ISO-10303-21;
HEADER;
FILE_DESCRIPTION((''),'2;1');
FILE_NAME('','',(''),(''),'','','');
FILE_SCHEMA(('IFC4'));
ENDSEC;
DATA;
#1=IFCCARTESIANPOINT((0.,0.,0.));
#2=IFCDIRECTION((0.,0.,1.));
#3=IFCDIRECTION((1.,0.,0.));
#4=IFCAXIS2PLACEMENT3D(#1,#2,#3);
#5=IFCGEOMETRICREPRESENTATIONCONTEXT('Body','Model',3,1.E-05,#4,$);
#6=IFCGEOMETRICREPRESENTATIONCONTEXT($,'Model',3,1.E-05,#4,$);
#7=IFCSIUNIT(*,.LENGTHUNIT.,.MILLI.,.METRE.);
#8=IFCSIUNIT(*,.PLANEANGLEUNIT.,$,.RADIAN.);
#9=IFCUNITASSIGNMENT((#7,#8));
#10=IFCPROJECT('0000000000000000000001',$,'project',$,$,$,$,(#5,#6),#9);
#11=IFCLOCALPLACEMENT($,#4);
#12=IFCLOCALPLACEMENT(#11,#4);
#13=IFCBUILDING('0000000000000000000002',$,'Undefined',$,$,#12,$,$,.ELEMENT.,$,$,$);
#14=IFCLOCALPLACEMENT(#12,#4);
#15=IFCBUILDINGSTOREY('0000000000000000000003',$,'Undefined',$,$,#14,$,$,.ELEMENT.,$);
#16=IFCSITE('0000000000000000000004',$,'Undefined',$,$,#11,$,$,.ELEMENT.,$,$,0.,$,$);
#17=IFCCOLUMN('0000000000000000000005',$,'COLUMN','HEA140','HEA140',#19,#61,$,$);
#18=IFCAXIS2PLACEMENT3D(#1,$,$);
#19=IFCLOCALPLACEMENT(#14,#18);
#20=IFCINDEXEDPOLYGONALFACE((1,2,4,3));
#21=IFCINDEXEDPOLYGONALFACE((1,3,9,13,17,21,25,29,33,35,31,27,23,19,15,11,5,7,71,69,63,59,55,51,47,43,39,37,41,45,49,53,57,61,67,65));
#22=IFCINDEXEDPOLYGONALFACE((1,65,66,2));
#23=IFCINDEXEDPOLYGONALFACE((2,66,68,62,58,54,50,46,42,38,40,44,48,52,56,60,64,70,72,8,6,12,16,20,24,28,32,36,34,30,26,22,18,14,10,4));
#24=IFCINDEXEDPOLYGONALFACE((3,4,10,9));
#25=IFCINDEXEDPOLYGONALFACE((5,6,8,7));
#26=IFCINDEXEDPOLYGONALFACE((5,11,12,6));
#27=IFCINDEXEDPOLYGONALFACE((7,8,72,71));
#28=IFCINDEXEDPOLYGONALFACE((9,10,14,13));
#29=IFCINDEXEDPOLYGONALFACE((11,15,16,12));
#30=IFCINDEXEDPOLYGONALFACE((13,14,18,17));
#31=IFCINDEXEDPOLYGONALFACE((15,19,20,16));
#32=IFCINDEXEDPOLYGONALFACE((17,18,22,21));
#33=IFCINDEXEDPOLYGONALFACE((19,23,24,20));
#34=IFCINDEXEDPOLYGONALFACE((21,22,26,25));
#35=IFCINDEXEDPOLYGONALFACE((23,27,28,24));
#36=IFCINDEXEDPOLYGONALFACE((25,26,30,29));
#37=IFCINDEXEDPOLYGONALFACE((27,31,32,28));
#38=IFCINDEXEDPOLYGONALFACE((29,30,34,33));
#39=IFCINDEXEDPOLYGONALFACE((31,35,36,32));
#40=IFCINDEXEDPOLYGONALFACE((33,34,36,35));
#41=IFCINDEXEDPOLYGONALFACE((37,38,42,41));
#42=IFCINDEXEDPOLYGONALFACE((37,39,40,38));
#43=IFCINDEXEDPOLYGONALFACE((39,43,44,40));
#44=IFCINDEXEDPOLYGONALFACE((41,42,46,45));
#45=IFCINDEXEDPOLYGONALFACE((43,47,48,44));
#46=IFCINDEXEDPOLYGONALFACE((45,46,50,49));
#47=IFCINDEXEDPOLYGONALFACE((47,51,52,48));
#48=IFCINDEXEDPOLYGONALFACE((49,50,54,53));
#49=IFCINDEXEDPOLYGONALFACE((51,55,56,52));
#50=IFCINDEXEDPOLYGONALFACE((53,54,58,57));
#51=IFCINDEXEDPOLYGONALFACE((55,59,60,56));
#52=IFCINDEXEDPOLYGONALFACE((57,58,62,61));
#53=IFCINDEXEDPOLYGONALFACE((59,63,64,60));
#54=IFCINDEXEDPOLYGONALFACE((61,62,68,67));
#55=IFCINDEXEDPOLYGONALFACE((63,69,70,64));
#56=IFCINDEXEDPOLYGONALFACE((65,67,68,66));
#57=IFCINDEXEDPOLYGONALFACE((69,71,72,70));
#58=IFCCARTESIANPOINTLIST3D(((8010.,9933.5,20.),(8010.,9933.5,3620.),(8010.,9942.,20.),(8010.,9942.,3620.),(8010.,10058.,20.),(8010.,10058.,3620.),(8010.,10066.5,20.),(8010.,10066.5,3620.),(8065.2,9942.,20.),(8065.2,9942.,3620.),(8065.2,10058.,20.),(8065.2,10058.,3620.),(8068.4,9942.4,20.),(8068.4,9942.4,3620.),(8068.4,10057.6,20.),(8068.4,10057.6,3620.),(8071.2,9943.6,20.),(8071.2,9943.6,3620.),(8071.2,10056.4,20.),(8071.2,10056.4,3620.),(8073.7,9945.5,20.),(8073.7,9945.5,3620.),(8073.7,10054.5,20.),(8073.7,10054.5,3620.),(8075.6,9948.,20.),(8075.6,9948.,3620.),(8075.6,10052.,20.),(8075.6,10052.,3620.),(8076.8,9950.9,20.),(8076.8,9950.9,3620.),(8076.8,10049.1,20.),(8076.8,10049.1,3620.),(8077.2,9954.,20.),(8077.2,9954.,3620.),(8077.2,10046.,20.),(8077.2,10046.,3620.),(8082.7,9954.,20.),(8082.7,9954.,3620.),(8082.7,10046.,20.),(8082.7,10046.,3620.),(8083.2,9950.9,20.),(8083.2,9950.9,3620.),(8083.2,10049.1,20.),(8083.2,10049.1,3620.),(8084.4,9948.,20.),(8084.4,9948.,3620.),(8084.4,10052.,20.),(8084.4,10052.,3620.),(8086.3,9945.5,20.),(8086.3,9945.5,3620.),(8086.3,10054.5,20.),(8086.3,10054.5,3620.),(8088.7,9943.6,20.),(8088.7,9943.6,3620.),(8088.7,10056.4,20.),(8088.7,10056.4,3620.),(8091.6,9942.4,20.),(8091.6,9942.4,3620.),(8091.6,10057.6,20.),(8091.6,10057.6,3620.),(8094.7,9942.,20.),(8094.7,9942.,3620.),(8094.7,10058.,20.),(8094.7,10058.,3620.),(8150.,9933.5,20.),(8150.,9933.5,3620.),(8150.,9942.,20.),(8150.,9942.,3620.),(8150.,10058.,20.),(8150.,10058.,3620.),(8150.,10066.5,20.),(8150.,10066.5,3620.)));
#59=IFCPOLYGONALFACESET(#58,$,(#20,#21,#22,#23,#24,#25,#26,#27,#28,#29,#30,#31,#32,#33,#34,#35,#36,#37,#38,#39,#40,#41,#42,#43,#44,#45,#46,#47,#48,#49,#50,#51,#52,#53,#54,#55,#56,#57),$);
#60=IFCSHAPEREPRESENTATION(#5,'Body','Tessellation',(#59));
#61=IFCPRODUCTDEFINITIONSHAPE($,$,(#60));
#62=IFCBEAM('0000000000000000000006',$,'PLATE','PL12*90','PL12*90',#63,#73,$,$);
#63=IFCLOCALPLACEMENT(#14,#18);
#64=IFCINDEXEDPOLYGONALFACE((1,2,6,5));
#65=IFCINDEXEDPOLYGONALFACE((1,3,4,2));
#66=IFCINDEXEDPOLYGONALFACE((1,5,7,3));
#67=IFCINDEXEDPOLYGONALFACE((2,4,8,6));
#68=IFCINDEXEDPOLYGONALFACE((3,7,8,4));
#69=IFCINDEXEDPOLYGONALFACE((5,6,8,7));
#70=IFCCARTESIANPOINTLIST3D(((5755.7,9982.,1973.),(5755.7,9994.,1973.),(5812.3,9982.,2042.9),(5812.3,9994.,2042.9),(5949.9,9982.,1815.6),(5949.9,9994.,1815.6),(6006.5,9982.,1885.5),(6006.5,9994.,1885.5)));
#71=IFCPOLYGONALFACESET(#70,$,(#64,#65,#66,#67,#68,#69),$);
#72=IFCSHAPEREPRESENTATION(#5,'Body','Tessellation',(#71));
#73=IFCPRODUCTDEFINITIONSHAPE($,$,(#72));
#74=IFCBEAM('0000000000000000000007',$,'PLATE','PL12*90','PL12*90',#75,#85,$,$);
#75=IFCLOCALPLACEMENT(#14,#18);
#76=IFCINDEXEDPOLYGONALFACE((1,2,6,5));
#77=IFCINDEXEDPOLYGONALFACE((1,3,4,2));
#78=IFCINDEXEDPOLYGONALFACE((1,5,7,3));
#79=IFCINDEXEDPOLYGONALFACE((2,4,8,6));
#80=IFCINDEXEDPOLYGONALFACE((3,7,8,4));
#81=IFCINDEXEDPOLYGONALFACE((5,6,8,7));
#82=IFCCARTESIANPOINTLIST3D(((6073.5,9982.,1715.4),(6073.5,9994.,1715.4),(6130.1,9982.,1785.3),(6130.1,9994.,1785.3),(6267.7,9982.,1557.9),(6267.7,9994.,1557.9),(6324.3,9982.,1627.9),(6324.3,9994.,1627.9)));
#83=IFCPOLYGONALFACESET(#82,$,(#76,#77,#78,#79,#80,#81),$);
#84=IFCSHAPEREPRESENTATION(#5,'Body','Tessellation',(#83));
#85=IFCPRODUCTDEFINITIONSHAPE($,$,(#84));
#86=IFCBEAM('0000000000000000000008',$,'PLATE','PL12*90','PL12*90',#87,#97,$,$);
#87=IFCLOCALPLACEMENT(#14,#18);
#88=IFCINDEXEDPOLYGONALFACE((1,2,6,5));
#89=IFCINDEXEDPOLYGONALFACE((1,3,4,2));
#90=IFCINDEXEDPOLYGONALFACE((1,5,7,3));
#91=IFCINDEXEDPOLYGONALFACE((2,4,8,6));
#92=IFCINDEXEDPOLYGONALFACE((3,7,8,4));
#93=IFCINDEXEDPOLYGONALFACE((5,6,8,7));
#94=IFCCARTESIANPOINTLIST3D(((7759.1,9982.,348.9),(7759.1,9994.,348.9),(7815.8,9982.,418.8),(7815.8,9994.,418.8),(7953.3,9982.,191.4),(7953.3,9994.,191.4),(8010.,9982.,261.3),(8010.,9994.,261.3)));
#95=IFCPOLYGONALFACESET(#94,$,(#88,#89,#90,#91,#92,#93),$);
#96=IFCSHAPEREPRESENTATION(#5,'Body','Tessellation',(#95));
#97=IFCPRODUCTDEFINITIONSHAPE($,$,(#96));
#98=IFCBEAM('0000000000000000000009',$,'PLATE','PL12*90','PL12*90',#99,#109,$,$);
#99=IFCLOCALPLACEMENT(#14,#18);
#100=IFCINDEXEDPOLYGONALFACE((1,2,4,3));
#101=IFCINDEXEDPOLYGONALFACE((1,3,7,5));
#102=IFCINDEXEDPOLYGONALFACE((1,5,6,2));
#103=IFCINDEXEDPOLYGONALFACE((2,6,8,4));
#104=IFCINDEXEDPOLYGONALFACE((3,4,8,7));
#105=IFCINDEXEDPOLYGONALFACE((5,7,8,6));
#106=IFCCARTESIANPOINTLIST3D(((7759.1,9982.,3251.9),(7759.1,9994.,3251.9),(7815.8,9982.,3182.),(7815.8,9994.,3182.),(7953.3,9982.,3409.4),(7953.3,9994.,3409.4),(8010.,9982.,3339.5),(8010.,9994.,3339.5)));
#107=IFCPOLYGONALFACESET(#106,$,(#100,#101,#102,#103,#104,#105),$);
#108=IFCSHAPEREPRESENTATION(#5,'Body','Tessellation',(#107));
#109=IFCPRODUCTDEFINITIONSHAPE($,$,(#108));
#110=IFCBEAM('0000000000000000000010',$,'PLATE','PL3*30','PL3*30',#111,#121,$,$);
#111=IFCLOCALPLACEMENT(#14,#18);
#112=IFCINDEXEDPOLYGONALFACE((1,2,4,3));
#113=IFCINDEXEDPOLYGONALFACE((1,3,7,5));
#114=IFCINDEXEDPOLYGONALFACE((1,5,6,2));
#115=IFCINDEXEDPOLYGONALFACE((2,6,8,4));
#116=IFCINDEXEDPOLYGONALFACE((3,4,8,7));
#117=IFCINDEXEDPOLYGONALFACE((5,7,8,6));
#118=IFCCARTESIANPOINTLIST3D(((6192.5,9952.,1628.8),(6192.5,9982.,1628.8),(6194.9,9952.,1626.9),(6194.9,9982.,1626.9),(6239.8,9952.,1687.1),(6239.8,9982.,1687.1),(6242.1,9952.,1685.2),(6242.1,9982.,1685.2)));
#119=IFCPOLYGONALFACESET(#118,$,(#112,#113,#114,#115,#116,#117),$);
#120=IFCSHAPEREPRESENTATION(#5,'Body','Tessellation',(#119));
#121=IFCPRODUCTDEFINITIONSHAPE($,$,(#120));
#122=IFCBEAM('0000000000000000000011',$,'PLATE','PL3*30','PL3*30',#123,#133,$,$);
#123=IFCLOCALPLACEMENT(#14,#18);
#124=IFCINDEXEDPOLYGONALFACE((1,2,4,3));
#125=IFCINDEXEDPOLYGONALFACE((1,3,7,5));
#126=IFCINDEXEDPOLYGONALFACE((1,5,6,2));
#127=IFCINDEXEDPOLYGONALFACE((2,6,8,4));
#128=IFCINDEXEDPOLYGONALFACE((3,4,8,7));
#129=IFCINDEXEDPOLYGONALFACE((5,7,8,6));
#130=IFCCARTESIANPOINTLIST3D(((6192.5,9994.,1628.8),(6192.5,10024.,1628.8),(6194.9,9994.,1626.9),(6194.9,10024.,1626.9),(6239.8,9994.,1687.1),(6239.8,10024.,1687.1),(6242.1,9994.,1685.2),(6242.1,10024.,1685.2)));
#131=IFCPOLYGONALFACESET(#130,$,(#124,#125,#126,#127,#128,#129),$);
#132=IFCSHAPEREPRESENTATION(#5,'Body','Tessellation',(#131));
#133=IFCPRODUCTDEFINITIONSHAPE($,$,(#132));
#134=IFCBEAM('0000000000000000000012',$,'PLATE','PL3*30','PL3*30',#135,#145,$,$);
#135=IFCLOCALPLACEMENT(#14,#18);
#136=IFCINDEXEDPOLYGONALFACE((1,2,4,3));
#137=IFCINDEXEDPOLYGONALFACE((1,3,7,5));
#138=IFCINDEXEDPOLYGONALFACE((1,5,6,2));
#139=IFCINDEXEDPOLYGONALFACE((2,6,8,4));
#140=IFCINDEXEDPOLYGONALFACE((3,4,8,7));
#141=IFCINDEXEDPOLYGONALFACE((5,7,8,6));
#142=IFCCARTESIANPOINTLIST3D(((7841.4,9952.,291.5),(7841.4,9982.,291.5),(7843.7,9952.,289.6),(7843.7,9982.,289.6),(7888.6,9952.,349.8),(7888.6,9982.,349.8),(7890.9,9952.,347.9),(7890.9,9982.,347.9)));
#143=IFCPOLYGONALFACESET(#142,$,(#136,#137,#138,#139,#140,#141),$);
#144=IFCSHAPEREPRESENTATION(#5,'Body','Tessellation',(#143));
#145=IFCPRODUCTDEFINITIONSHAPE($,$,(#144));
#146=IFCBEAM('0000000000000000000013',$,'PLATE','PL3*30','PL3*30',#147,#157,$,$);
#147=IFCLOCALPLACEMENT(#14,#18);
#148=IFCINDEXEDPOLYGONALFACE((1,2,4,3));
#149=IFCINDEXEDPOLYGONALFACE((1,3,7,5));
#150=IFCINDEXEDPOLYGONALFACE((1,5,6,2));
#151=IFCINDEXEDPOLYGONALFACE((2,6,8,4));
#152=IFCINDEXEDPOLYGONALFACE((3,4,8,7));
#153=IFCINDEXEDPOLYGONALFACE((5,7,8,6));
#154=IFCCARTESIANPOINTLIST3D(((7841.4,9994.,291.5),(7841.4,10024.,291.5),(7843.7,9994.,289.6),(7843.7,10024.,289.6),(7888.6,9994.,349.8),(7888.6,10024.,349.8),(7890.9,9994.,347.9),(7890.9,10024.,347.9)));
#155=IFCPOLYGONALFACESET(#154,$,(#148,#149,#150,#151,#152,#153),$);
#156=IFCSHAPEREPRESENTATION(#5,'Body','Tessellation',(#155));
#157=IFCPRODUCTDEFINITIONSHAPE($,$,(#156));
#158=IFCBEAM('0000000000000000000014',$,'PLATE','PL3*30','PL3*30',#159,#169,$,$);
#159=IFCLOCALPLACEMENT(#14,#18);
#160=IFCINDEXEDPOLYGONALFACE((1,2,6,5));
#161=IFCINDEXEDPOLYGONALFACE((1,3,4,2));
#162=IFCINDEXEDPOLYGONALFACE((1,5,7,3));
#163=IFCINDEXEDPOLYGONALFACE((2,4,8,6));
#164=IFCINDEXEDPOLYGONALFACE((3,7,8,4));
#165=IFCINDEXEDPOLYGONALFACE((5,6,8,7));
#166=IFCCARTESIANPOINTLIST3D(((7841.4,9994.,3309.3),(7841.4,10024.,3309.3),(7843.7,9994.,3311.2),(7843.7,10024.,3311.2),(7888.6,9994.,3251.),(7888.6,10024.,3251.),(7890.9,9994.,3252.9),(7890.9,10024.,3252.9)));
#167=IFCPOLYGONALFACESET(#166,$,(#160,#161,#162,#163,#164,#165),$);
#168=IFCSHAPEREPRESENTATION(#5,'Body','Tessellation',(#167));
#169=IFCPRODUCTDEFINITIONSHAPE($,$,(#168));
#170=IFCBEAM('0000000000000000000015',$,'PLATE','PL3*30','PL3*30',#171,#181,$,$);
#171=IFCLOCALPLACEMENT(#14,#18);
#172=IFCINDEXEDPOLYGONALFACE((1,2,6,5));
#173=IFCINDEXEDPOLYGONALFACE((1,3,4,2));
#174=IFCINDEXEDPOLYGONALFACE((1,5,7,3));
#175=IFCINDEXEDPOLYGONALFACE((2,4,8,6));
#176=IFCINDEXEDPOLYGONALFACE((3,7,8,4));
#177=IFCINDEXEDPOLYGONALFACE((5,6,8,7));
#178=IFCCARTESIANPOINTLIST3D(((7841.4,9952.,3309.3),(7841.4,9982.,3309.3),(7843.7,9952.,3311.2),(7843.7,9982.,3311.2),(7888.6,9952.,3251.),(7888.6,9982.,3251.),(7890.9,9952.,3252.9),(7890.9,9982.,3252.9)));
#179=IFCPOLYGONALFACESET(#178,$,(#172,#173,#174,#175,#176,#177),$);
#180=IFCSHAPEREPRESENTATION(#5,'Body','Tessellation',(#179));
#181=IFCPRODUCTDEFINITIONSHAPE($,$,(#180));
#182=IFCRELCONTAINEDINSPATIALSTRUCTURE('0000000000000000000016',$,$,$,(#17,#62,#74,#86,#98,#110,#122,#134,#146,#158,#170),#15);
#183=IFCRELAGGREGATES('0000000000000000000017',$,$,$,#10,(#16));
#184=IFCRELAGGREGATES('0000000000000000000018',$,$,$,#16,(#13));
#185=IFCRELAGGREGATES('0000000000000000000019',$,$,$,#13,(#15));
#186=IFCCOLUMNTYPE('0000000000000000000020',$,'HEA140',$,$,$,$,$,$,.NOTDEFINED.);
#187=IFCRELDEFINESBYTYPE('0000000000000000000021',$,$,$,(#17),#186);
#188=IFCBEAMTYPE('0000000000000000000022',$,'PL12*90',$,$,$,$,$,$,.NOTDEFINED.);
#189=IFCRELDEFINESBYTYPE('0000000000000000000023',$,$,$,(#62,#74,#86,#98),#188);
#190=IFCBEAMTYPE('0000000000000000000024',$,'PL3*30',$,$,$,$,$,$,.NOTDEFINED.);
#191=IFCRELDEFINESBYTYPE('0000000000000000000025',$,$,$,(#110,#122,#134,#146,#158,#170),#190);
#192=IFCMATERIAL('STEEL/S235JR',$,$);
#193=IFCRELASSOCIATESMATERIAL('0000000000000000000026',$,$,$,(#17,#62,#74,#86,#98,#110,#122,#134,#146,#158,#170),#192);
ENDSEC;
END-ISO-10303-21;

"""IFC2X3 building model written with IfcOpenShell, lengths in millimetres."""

from ifc_helpers import new_model, si_unit, frame, origin_with_axes, origin_2d_with_axis, place, context, project, spatial, rectangle, i_section, extrude, material, type_object, element, save


model = new_model("IFC2X3")

# Units and contexts
model_context_1 = context("Model", 3, precision=1e-05, world=origin_with_axes(), identifier="Body")
model_context_2 = context("Model", 3, precision=1e-05, world=origin_with_axes())
ifc_project = project(units=[si_unit("LENGTHUNIT", "METRE", prefix="MILLI"), si_unit("PLANEANGLEUNIT", "RADIAN")], contexts=[model_context_1, model_context_2])

# Site, building, storey
site_placement = place(None, origin_with_axes())
site = spatial("IfcSite", under=ifc_project, at=site_placement, Name="Undefined", CompositionType="ELEMENT", RefElevation=0.0)
building_placement = place(site_placement, origin_with_axes())
building = spatial("IfcBuilding", under=site, at=building_placement, Name="Undefined", CompositionType="ELEMENT")
storey_placement = place(building_placement, origin_with_axes())
storey = spatial("IfcBuildingStorey", under=building, at=storey_placement, Name="Undefined", CompositionType="ELEMENT")

# Column
ifc_material = material(Name="STEEL/S235JR")
column_type = type_object("IfcColumnType", Name="HEA140", PredefinedType="NOTDEFINED")
column_placement = place(storey_placement, frame((8080.0, 10000.0, -180.0), z_axis=(0.0, 0.0, 1.0), x_axis=(1.0, 0.0, 0.0)))
element("IfcColumn", 1, at=column_placement, inside=storey, type_object=column_type, material=ifc_material, Name="COLUMN", Description="HEA140", ObjectType="HEA140", context=model_context_1, shape_type="SweptSolid", body=[
    extrude(i_section(OverallWidth=140.0, OverallDepth=133.0, WebThickness=5.5, FlangeThickness=8.5, FilletRadius=12.0, at=origin_2d_with_axis()), frame((0.0, 0.0, 3800.0), z_axis=(0.0, 0.0, -1.0), x_axis=(-1.0, 0.0, 0.0)), (0.0, 0.0, 1.0), 3600.0),
])

# Beams
beam_type_1 = type_object("IfcBeamType", Name="PL12*90", PredefinedType="NOTDEFINED")
for number, where, z_axis, x_axis, name in (
    (2, (5978.2, 9988.0, 1850.5), (0.629738, 0.0, 0.776808), (-0.776808, 0.0, 0.629738), "PLATE"),
    (3, (6101.8, 9988.0, 1750.3), (0.629738, 0.0, 0.776808), (0.776808, 0.0, -0.629738), "PLATE"),
    (4, (7981.7, 9988.0, 226.4), (-0.629738, 0.0, -0.776808), (-0.776808, 0.0, 0.629738), "PLATE"),
):
    element("IfcBeam", number, at=place(storey_placement, frame(where, z_axis=z_axis, x_axis=x_axis)), inside=storey, type_object=beam_type_1, material=ifc_material, Name=name, Description="PL12*90", ObjectType="PL12*90", context=model_context_1, shape_type="SweptSolid", body=[
        extrude(rectangle(XDim=12.0, YDim=90.0, at=origin_2d_with_axis()), frame((250.0, 0.0, 0.0), z_axis=(-1.0, 0.0, 0.0), x_axis=(0.0, -1.0, 0.0)), (0.0, 0.0, 1.0), 250.0),
    ])
beam_1_placement = place(storey_placement, frame((7981.7, 9988.0, 3374.5), z_axis=(-0.629835, 0.0, 0.776729), x_axis=(-0.776729, 0.0, -0.629835)))
element("IfcBeam", 5, at=beam_1_placement, inside=storey, type_object=beam_type_1, material=ifc_material, Name="PLATE", Description="PL12*90", ObjectType="PL12*90", context=model_context_1, shape_type="SweptSolid", body=[
    extrude(rectangle(XDim=12.0, YDim=90.0, at=origin_2d_with_axis()), frame((250.0, 0.0, 0.0), z_axis=(-1.0, 0.0, 0.0), x_axis=(0.0, -1.0, 0.0)), (0.0, 0.0, 1.0), 250.0),
])
beam_type_2 = type_object("IfcBeamType", Name="PL3*30", PredefinedType="NOTDEFINED")
for number, where, z_axis, x_axis, name in (
    (6, (6193.7, 9967.0, 1627.9), (0.0, 1.0, 0.0), (0.629738, 0.0, 0.776808), "PLATE"),
    (7, (6193.7, 10009.0, 1627.9), (0.0, -1.0, 0.0), (0.629738, 0.0, 0.776808), "PLATE"),
):
    element("IfcBeam", number, at=place(storey_placement, frame(where, z_axis=z_axis, x_axis=x_axis)), inside=storey, type_object=beam_type_2, material=ifc_material, Name=name, Description="PL3*30", ObjectType="PL3*30", context=model_context_1, shape_type="SweptSolid", body=[
        extrude(rectangle(XDim=3.0, YDim=30.0, at=origin_2d_with_axis()), frame((75.0, 0.0, 0.0), z_axis=(-1.0, 0.0, 0.0), x_axis=(0.0, -1.0, 0.0)), (0.0, 0.0, 1.0), 75.0),
    ])
for number, where, z_axis, x_axis, name in (
    (8, (7889.8, 9967.0, 348.8), (0.0, 1.0, 0.0), (-0.629738, 0.0, -0.776808), "PLATE"),
    (9, (7889.8, 10009.0, 348.8), (0.0, -1.0, 0.0), (-0.629738, 0.0, -0.776808), "PLATE"),
    (10, (7889.8, 10009.0, 3252.0), (0.0, -1.0, 0.0), (-0.629835, 0.0, 0.776729), "PLATE"),
    (11, (7889.8, 9967.0, 3252.0), (0.0, 1.0, 0.0), (-0.629835, 0.0, 0.776729), "PLATE"),
):
    element("IfcBeam", number, at=place(storey_placement, frame(where, z_axis=z_axis, x_axis=x_axis)), inside=storey, type_object=beam_type_2, material=ifc_material, Name=name, Description="PL3*30", ObjectType="PL3*30", context=model_context_1, shape_type="SweptSolid", body=[
        extrude(rectangle(XDim=3.0, YDim=30.0, at=origin_2d_with_axis()), frame((75.0, 0.0, 0.0), z_axis=(-1.0, 0.0, 0.0), x_axis=(0.0, -1.0, 0.0)), (0.0, 0.0, 1.0), 75.0),
    ])

save(model, "model.ifc")
